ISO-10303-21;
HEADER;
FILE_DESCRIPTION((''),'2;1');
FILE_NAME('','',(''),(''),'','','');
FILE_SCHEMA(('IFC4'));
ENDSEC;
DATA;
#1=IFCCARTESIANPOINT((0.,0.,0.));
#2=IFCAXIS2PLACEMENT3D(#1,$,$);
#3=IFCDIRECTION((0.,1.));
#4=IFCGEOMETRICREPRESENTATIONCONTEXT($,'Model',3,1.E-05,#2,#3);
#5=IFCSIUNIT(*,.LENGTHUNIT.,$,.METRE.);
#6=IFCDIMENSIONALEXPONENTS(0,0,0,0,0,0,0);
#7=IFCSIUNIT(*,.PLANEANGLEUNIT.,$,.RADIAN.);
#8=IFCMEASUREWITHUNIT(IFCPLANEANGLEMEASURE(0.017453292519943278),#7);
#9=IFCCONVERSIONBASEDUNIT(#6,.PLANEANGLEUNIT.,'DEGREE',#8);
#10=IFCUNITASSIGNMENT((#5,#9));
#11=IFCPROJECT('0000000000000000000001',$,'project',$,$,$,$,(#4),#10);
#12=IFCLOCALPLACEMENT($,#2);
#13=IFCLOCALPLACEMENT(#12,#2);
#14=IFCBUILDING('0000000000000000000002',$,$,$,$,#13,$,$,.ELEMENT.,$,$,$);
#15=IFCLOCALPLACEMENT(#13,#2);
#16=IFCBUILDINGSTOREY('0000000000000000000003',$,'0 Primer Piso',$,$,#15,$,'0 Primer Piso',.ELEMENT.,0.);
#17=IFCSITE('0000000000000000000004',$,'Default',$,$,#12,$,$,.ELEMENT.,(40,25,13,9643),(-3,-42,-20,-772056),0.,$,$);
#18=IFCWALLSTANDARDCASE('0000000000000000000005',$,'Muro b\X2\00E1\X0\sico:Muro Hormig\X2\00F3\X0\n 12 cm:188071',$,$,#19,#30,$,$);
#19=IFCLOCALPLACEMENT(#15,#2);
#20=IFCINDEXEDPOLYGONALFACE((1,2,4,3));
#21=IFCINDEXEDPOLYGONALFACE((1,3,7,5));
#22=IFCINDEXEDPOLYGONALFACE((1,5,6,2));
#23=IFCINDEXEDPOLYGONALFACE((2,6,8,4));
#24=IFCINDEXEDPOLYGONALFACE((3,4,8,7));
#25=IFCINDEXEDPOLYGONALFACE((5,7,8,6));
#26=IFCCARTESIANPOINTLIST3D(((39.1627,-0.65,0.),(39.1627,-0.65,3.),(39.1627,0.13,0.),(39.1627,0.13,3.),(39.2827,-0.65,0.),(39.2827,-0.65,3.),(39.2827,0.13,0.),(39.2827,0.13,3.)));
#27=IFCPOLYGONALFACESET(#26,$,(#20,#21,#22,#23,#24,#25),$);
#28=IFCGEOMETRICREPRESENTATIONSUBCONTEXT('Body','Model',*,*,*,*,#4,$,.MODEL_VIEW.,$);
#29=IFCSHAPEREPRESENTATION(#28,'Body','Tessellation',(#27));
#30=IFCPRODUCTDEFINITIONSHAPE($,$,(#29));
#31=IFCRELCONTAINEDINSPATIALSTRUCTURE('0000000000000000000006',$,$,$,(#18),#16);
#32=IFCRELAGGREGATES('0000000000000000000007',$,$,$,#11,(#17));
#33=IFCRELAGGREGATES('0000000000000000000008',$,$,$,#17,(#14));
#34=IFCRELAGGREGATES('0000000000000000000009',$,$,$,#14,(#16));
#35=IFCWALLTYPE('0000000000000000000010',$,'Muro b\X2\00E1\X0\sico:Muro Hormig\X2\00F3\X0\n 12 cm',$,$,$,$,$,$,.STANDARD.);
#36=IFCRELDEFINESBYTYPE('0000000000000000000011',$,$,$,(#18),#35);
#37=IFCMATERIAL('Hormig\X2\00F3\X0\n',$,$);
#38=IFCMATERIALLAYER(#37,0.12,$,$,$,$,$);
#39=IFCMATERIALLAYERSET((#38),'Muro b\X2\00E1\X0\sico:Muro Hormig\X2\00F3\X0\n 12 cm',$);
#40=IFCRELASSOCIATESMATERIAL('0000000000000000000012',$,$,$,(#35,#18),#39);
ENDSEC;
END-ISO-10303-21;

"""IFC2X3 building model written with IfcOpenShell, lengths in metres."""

from ifc_helpers import new_model, entity, si_unit, converted_unit, direction, frame, frame_2d, origin, place, context, subcontext, project, spatial, rectangle, extrude, material, layer, layer_set, layer_usage, type_object, element, save


model = new_model("IFC2X3")

# Units and contexts
model_context = context("Model", 3, precision=1e-05, world=origin(), true_north=direction((0.0, 1.0)))
body_context = subcontext(model_context, "Body", "Model", "MODEL_VIEW")
ifc_project = project(units=[si_unit("LENGTHUNIT", "METRE"), converted_unit("PLANEANGLEUNIT", "DEGREE", entity("IfcPlaneAngleMeasure", 0.017453292519943278), si_unit("PLANEANGLEUNIT", "RADIAN"), dimensions=[0, 0, 0, 0, 0, 0, 0])], contexts=[model_context])

# Site, building, storey
site_placement = place(None, origin())
site = spatial("IfcSite", under=ifc_project, at=site_placement, Name="Default", CompositionType="ELEMENT", RefLatitude=(40, 25, 13, 9643), RefLongitude=(-3, -42, -20, -772056), RefElevation=0.0)
building_placement = place(site_placement, origin())
building = spatial("IfcBuilding", under=site, at=building_placement, CompositionType="ELEMENT")
storey_placement = place(building_placement, origin())
storey = spatial("IfcBuildingStorey", under=building, at=storey_placement, Name="0 Primer Piso", LongName="0 Primer Piso", CompositionType="ELEMENT", Elevation=0.0)

# Shared definitions
ifc_material = material(Name="Hormigón")
ifc_layer = layer(ifc_material, 0.12)
ifc_layer_set = layer_set([ifc_layer], Name="Muro básico:Muro Hormigón 12 cm")
wall_type = type_object("IfcWallType", Name="Muro básico:Muro Hormigón 12 cm", PredefinedType="STANDARD", material=ifc_layer_set)

# Wall
ifc_layer_usage_1 = layer_usage(ifc_layer_set, "AXIS2", "NEGATIVE", 0.06)
wall_1_placement = place(storey_placement, frame((39.2227, -0.65, 0.0), z_axis=(0.0, 0.0, 1.0), x_axis=(0.0, 1.0, 0.0)))
element("IfcWallStandardCase", 1, at=wall_1_placement, inside=storey, type_object=wall_type, material=ifc_layer_usage_1, Name="Muro básico:Muro Hormigón 12 cm:188071", context=body_context, shape_type="SweptSolid", body=[
    extrude(rectangle(XDim=0.78, YDim=0.12, at=frame_2d((0.39, 0.0), x_axis=(-1.0, 0.0))), origin(), (0.0, 0.0, 1.0), 3.0),
])

save(model, "model.ifc")
